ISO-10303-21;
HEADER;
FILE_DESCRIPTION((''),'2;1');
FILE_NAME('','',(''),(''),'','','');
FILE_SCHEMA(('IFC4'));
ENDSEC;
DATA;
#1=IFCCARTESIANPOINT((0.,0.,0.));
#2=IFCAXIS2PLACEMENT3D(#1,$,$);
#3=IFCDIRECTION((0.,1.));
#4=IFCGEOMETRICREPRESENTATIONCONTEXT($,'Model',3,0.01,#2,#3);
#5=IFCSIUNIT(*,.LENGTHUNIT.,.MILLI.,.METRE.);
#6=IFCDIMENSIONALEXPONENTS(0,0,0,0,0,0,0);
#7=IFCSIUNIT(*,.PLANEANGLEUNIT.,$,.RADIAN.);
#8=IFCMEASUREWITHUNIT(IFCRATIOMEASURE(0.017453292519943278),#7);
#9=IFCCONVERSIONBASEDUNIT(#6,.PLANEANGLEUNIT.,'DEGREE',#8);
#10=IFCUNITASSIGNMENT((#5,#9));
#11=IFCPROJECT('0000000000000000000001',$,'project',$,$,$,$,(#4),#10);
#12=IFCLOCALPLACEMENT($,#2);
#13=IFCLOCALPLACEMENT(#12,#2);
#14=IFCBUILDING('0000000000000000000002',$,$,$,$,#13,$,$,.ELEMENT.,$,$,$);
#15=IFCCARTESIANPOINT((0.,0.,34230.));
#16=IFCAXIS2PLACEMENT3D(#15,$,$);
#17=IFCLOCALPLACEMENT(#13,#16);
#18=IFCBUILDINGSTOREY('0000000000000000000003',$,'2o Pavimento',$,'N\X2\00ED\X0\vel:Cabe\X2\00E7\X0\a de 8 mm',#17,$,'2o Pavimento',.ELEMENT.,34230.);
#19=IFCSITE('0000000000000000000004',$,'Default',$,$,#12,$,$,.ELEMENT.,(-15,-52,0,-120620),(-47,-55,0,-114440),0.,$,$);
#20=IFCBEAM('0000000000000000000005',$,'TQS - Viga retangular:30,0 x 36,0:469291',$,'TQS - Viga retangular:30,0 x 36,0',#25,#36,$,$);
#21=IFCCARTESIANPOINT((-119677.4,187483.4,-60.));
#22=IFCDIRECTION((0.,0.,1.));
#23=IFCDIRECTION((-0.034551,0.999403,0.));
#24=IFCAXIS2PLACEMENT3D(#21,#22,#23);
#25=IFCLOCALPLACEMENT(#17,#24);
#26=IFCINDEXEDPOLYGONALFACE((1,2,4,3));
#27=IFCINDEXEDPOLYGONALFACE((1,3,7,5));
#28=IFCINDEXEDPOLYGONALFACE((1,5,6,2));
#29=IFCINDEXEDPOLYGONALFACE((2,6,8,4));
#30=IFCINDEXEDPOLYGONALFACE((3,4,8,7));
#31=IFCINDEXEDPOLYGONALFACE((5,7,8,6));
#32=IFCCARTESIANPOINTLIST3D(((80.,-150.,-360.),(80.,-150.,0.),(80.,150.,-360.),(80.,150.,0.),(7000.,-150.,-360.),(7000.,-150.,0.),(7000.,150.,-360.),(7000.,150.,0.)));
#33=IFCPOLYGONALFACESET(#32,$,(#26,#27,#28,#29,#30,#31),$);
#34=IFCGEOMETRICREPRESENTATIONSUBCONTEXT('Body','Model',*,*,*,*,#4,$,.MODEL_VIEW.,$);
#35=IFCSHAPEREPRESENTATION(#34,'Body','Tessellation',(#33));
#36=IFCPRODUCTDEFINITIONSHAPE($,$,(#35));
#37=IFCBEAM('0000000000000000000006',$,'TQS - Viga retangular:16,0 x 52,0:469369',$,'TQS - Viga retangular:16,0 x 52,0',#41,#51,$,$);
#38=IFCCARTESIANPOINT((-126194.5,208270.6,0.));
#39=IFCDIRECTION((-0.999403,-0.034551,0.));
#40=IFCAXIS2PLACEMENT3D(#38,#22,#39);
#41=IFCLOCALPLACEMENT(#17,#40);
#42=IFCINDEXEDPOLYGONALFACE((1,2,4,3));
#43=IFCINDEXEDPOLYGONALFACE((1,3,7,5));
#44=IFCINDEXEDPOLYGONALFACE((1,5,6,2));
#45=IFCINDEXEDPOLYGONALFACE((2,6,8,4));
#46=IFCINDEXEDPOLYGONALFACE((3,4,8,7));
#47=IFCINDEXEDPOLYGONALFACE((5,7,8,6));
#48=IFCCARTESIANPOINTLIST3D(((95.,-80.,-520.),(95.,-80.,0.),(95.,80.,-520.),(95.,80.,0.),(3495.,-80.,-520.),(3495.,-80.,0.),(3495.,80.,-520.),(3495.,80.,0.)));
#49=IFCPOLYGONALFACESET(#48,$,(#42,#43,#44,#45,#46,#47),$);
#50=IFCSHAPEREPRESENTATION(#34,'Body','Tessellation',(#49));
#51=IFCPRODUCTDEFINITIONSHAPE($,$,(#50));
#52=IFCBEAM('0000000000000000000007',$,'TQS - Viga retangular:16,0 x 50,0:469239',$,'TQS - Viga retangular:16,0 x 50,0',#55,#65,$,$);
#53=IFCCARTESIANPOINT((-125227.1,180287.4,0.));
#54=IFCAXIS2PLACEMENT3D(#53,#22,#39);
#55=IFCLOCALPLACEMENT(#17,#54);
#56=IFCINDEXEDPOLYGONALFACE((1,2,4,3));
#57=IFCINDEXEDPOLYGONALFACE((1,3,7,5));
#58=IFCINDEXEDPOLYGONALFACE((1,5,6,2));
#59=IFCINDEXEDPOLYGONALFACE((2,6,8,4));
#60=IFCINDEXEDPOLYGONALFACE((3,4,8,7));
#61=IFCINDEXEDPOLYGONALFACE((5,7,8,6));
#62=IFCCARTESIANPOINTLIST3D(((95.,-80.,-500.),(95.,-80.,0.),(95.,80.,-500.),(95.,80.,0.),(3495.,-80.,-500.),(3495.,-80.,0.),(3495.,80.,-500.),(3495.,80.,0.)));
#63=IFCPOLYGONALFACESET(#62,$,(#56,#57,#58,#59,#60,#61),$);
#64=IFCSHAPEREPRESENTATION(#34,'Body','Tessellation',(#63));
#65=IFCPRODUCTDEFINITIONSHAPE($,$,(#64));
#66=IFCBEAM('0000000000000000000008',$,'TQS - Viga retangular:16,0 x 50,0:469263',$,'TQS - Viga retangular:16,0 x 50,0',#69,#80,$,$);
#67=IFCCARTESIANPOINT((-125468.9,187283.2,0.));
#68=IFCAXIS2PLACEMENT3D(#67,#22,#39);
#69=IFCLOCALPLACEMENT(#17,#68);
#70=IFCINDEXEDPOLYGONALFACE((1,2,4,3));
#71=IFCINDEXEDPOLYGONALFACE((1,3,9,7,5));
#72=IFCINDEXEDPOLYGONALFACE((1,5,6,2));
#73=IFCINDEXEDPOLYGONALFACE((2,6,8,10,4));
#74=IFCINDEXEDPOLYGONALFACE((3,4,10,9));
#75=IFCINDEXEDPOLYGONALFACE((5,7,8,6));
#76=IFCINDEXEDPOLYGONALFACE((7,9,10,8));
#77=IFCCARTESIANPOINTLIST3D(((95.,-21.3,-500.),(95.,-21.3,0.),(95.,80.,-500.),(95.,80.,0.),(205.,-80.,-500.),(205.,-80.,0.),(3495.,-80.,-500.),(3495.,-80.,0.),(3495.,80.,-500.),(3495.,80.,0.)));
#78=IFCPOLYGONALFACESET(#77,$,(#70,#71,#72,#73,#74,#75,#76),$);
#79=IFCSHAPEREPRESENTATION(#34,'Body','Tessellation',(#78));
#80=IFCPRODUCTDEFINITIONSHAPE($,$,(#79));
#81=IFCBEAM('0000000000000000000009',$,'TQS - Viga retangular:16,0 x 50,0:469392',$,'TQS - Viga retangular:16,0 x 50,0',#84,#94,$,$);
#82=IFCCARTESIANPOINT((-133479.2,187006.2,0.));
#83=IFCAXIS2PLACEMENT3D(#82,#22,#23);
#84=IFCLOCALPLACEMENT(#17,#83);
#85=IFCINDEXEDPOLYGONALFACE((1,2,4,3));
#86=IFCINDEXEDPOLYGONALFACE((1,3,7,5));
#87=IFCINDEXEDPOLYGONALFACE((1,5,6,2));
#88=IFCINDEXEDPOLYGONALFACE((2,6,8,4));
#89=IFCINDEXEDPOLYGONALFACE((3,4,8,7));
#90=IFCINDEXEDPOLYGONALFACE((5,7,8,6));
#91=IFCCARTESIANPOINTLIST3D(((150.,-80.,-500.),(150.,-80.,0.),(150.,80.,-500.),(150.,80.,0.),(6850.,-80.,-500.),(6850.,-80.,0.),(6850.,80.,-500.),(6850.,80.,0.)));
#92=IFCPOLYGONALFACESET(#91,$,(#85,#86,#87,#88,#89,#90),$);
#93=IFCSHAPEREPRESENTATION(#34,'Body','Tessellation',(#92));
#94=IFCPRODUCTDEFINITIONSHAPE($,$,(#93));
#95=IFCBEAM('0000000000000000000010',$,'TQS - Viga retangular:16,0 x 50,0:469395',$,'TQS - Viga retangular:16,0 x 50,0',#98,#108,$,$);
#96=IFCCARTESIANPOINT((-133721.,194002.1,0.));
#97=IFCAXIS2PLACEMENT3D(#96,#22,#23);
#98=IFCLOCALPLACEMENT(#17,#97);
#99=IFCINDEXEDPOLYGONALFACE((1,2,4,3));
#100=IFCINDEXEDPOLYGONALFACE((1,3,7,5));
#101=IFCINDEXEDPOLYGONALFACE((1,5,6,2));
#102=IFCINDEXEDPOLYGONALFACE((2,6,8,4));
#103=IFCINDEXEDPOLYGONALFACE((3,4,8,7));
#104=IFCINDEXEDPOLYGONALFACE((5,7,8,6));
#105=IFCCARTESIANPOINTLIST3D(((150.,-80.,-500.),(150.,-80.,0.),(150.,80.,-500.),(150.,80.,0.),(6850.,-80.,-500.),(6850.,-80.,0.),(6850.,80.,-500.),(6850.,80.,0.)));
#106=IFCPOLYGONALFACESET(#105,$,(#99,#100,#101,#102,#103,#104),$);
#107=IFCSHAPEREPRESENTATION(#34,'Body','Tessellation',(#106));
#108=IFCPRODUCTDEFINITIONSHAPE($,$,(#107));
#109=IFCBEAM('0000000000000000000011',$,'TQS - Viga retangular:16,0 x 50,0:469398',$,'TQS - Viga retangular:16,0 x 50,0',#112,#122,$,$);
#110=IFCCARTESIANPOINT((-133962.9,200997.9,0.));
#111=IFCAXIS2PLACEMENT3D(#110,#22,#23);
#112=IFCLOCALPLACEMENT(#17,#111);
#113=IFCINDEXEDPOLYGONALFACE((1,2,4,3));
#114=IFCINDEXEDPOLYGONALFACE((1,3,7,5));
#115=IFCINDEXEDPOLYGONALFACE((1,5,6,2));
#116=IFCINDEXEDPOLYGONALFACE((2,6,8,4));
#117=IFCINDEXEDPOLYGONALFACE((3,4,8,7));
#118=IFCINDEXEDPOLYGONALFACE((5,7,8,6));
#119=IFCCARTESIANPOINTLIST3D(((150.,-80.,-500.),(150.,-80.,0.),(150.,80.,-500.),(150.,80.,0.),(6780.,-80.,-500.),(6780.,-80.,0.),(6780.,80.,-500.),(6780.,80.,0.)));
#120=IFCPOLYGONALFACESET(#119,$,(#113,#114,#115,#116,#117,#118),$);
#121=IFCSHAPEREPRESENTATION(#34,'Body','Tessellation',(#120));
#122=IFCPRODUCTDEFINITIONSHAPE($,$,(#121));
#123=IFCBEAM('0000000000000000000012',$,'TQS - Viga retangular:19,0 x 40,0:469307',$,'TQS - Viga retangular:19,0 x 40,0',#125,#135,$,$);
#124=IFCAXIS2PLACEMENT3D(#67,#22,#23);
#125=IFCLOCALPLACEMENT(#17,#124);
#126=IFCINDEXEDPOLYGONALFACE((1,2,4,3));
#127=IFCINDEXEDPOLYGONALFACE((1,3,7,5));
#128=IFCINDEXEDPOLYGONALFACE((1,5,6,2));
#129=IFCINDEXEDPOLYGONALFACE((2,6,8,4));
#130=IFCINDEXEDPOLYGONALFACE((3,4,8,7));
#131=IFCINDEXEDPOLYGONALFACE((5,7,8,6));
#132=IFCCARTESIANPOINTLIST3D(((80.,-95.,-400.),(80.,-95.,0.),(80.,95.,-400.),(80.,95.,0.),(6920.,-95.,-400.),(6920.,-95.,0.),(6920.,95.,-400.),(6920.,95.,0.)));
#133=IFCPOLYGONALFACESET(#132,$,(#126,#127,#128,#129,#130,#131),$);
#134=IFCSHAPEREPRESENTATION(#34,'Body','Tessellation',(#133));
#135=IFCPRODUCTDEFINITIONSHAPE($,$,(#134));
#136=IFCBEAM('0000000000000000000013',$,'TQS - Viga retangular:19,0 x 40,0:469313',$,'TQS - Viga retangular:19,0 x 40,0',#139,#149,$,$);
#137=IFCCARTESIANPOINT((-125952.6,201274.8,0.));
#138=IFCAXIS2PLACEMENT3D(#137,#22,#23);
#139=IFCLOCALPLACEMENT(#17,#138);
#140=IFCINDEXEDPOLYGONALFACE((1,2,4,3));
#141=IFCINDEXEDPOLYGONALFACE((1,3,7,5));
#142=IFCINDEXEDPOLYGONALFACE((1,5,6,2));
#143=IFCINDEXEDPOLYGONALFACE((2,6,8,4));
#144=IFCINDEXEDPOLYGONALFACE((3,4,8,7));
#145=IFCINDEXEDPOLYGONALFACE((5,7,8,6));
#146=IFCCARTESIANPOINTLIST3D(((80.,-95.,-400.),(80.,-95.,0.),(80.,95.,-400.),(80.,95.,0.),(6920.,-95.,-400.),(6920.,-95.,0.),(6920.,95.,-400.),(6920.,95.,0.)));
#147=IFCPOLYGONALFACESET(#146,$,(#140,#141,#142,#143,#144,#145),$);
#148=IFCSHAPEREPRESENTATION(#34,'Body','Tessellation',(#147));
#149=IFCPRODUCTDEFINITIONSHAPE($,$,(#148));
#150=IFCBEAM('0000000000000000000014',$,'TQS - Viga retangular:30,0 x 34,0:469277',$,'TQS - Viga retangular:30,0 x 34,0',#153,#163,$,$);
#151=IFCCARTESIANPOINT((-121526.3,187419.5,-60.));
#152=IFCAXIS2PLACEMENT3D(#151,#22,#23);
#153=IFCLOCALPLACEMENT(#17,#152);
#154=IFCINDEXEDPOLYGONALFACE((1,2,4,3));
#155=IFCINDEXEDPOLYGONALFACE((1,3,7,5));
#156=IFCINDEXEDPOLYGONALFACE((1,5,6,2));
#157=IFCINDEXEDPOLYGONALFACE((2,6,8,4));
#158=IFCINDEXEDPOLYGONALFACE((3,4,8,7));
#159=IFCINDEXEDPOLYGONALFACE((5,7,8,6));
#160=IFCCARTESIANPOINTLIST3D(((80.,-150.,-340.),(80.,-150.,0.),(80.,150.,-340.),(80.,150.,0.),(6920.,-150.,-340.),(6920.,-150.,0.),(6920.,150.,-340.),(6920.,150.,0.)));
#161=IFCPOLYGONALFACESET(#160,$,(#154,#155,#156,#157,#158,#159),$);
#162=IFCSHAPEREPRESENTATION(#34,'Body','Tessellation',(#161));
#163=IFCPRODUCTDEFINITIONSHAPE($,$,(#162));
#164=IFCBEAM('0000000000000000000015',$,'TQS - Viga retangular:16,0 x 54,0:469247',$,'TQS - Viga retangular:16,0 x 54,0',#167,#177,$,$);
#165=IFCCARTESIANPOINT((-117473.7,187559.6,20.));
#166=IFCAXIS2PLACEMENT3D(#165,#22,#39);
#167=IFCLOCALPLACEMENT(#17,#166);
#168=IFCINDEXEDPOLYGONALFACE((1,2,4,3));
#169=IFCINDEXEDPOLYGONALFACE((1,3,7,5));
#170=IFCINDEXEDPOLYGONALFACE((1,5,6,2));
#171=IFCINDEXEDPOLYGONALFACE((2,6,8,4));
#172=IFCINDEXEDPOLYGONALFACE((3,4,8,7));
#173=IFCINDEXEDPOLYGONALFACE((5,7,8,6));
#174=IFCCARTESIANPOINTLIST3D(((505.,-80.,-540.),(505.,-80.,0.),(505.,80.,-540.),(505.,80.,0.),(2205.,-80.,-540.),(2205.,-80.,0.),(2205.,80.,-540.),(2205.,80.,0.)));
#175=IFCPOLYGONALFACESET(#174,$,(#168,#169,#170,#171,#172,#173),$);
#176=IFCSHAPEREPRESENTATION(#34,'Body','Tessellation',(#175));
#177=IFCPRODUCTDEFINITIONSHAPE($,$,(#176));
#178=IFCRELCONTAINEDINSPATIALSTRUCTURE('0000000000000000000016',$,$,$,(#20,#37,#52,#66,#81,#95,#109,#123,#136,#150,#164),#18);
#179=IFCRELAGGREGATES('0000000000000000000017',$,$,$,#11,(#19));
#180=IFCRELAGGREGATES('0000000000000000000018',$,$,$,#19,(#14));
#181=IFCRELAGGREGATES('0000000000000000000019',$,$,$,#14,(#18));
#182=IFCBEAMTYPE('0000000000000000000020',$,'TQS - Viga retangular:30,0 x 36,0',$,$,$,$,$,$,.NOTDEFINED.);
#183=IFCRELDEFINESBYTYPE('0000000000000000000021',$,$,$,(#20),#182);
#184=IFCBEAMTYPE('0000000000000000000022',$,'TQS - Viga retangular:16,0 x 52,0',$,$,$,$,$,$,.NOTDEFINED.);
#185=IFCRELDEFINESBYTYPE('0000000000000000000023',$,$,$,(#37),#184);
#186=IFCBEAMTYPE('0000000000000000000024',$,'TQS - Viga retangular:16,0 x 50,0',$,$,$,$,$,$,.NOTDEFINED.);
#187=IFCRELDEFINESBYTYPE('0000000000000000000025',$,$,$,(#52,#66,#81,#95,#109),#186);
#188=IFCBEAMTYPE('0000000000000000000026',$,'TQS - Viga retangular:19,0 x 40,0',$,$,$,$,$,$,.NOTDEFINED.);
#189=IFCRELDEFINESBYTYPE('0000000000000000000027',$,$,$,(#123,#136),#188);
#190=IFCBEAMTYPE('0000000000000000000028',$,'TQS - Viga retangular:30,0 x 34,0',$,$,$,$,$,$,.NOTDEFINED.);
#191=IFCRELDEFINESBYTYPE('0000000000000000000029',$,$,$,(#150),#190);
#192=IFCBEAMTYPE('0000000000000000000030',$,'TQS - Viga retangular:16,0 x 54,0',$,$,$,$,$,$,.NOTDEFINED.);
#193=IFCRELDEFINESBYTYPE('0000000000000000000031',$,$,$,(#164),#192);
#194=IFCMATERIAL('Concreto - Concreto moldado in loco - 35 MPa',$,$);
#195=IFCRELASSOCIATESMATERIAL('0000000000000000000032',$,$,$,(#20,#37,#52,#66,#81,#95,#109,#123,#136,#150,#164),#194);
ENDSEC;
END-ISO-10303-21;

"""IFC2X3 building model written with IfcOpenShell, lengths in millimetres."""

from ifc_helpers import new_model, entity, si_unit, converted_unit, direction, frame, frame_2d, origin, origin_2d_with_axis, place, context, subcontext, project, spatial, rectangle, extrude, clip, halfspace, material, type_object, element, save


model = new_model("IFC2X3")

# Units and contexts
model_context = context("Model", 3, precision=0.01, world=origin(), true_north=direction((0.0, 1.0)))
body_context = subcontext(model_context, "Body", "Model", "MODEL_VIEW")
ifc_project = project(units=[si_unit("LENGTHUNIT", "METRE", prefix="MILLI"), converted_unit("PLANEANGLEUNIT", "DEGREE", entity("IfcRatioMeasure", 0.017453292519943278), si_unit("PLANEANGLEUNIT", "RADIAN"), dimensions=[0, 0, 0, 0, 0, 0, 0])], contexts=[model_context])

# Site, building, storey
site_placement = place(None, origin())
site = spatial("IfcSite", under=ifc_project, at=site_placement, Name="Default", CompositionType="ELEMENT", RefLatitude=(-15, -52, 0, -120620), RefLongitude=(-47, -55, 0, -114440), RefElevation=0.0)
building_placement = place(site_placement, origin())
building = spatial("IfcBuilding", under=site, at=building_placement, CompositionType="ELEMENT")
storey_placement = place(building_placement, frame((0.0, 0.0, 34230.0)))
storey = spatial("IfcBuildingStorey", under=building, at=storey_placement, Name="2o Pavimento", ObjectType="Nível:Cabeça de 8 mm", LongName="2o Pavimento", CompositionType="ELEMENT", Elevation=34230.0)

# Beams
ifc_material = material(Name="Concreto - Concreto moldado in loco - 35 MPa")
beam_type_1 = type_object("IfcBeamType", Name="TQS - Viga retangular:30,0 x 36,0", PredefinedType="NOTDEFINED")
beam_1_placement = place(storey_placement, frame((-119677.4, 187483.4, -60.0), z_axis=(0.0, 0.0, 1.0), x_axis=(-0.034551, 0.999403, 0.0)))
element("IfcBeam", 1, at=beam_1_placement, inside=storey, type_object=beam_type_1, material=ifc_material, Name="TQS - Viga retangular:30,0 x 36,0:469291", ObjectType="TQS - Viga retangular:30,0 x 36,0", context=body_context, shape_type="SweptSolid", body=[
    extrude(rectangle(XDim=360.0, YDim=300.0, at=frame_2d((0.0, 0.0), x_axis=(1.0, 0.0))), frame((80.0, 0.0, -180.0), z_axis=(1.0, 0.0, 0.0), x_axis=(0.0, 0.0, -1.0)), (0.0, 0.0, 1.0), 6920.0),
])
beam_type_2 = type_object("IfcBeamType", Name="TQS - Viga retangular:16,0 x 52,0", PredefinedType="NOTDEFINED")
beam_2_placement = place(storey_placement, frame((-126194.5, 208270.6, 0.0), z_axis=(0.0, 0.0, 1.0), x_axis=(-0.999403, -0.034551, 0.0)))
element("IfcBeam", 2, at=beam_2_placement, inside=storey, type_object=beam_type_2, material=ifc_material, Name="TQS - Viga retangular:16,0 x 52,0:469369", ObjectType="TQS - Viga retangular:16,0 x 52,0", context=body_context, shape_type="SweptSolid", body=[
    extrude(rectangle(XDim=520.0, YDim=160.0, at=frame_2d((0.0, 0.0), x_axis=(1.0, 0.0))), frame((95.0, 0.0, -260.0), z_axis=(1.0, 0.0, 0.0), x_axis=(0.0, 0.0, -1.0)), (0.0, 0.0, 1.0), 3400.0),
])
beam_type_3 = type_object("IfcBeamType", Name="TQS - Viga retangular:16,0 x 50,0", PredefinedType="NOTDEFINED")
beam_3_placement = place(storey_placement, frame((-125227.1, 180287.4, 0.0), z_axis=(0.0, 0.0, 1.0), x_axis=(-0.999403, -0.034551, 0.0)))
element("IfcBeam", 3, at=beam_3_placement, inside=storey, type_object=beam_type_3, material=ifc_material, Name="TQS - Viga retangular:16,0 x 50,0:469239", ObjectType="TQS - Viga retangular:16,0 x 50,0", context=body_context, shape_type="SweptSolid", body=[
    extrude(rectangle(XDim=500.0, YDim=160.0, at=origin_2d_with_axis()), frame((95.0, 0.0, -250.0), z_axis=(1.0, 0.0, 0.0), x_axis=(0.0, 0.0, -1.0)), (0.0, 0.0, 1.0), 3400.0),
])
beam_4_placement = place(storey_placement, frame((-125468.9, 187283.2, 0.0), z_axis=(0.0, 0.0, 1.0), x_axis=(-0.999403, -0.034551, 0.0)))
element("IfcBeam", 4, at=beam_4_placement, inside=storey, type_object=beam_type_3, material=ifc_material, Name="TQS - Viga retangular:16,0 x 50,0:469263", ObjectType="TQS - Viga retangular:16,0 x 50,0", context=body_context, shape_type="SweptSolid", body=[
    clip(extrude(rectangle(XDim=500.0, YDim=160.0, at=frame_2d((0.0, 0.0), x_axis=(1.0, 0.0))), frame((95.0, 0.0, -250.0), z_axis=(1.0, 0.0, 0.0), x_axis=(0.0, 0.0, -1.0)), (0.0, 0.0, 1.0), 3400.0), halfspace(frame((-95.0, 80.0, 0.0), z_axis=(-0.470588, -0.882353, 0.0), x_axis=(-0.882353, 0.470588, 0.0)), False)),
])
beam_5_placement = place(storey_placement, frame((-133479.2, 187006.2, 0.0), z_axis=(0.0, 0.0, 1.0), x_axis=(-0.034551, 0.999403, 0.0)))
element("IfcBeam", 5, at=beam_5_placement, inside=storey, type_object=beam_type_3, material=ifc_material, Name="TQS - Viga retangular:16,0 x 50,0:469392", ObjectType="TQS - Viga retangular:16,0 x 50,0", context=body_context, shape_type="SweptSolid", body=[
    extrude(rectangle(XDim=500.0, YDim=160.0, at=frame_2d((0.0, 0.0), x_axis=(1.0, 0.0))), frame((150.0, 0.0, -250.0), z_axis=(1.0, 0.0, 0.0), x_axis=(0.0, 0.0, -1.0)), (0.0, 0.0, 1.0), 6700.0),
])
beam_6_placement = place(storey_placement, frame((-133721.0, 194002.1, 0.0), z_axis=(0.0, 0.0, 1.0), x_axis=(-0.034551, 0.999403, 0.0)))
element("IfcBeam", 6, at=beam_6_placement, inside=storey, type_object=beam_type_3, material=ifc_material, Name="TQS - Viga retangular:16,0 x 50,0:469395", ObjectType="TQS - Viga retangular:16,0 x 50,0", context=body_context, shape_type="SweptSolid", body=[
    extrude(rectangle(XDim=500.0, YDim=160.0, at=frame_2d((0.0, 0.0), x_axis=(1.0, 0.0))), frame((150.0, 0.0, -250.0), z_axis=(1.0, 0.0, 0.0), x_axis=(0.0, 0.0, -1.0)), (0.0, 0.0, 1.0), 6700.0),
])
beam_7_placement = place(storey_placement, frame((-133962.9, 200997.9, 0.0), z_axis=(0.0, 0.0, 1.0), x_axis=(-0.034551, 0.999403, 0.0)))
element("IfcBeam", 7, at=beam_7_placement, inside=storey, type_object=beam_type_3, material=ifc_material, Name="TQS - Viga retangular:16,0 x 50,0:469398", ObjectType="TQS - Viga retangular:16,0 x 50,0", context=body_context, shape_type="SweptSolid", body=[
    extrude(rectangle(XDim=500.0, YDim=160.0, at=frame_2d((0.0, 0.0), x_axis=(1.0, 0.0))), frame((150.0, 0.0, -250.0), z_axis=(1.0, 0.0, 0.0), x_axis=(0.0, 0.0, -1.0)), (0.0, 0.0, 1.0), 6630.0),
])
beam_type_4 = type_object("IfcBeamType", Name="TQS - Viga retangular:19,0 x 40,0", PredefinedType="NOTDEFINED")
beam_8_placement = place(storey_placement, frame((-125468.9, 187283.2, 0.0), z_axis=(0.0, 0.0, 1.0), x_axis=(-0.034551, 0.999403, 0.0)))
element("IfcBeam", 8, at=beam_8_placement, inside=storey, type_object=beam_type_4, material=ifc_material, Name="TQS - Viga retangular:19,0 x 40,0:469307", ObjectType="TQS - Viga retangular:19,0 x 40,0", context=body_context, shape_type="SweptSolid", body=[
    extrude(rectangle(XDim=400.0, YDim=190.0, at=frame_2d((0.0, 0.0), x_axis=(1.0, 0.0))), frame((80.0, 0.0, -200.0), z_axis=(1.0, 0.0, 0.0), x_axis=(0.0, 0.0, -1.0)), (0.0, 0.0, 1.0), 6840.0),
])
beam_9_placement = place(storey_placement, frame((-125952.6, 201274.8, 0.0), z_axis=(0.0, 0.0, 1.0), x_axis=(-0.034551, 0.999403, 0.0)))
element("IfcBeam", 9, at=beam_9_placement, inside=storey, type_object=beam_type_4, material=ifc_material, Name="TQS - Viga retangular:19,0 x 40,0:469313", ObjectType="TQS - Viga retangular:19,0 x 40,0", context=body_context, shape_type="SweptSolid", body=[
    extrude(rectangle(XDim=400.0, YDim=190.0, at=frame_2d((0.0, 0.0), x_axis=(1.0, 0.0))), frame((80.0, 0.0, -200.0), z_axis=(1.0, 0.0, 0.0), x_axis=(0.0, 0.0, -1.0)), (0.0, 0.0, 1.0), 6840.0),
])
beam_type_5 = type_object("IfcBeamType", Name="TQS - Viga retangular:30,0 x 34,0", PredefinedType="NOTDEFINED")
beam_10_placement = place(storey_placement, frame((-121526.3, 187419.5, -60.0), z_axis=(0.0, 0.0, 1.0), x_axis=(-0.034551, 0.999403, 0.0)))
element("IfcBeam", 10, at=beam_10_placement, inside=storey, type_object=beam_type_5, material=ifc_material, Name="TQS - Viga retangular:30,0 x 34,0:469277", ObjectType="TQS - Viga retangular:30,0 x 34,0", context=body_context, shape_type="SweptSolid", body=[
    extrude(rectangle(XDim=340.0, YDim=300.0, at=frame_2d((0.0, 0.0), x_axis=(1.0, 0.0))), frame((80.0, 0.0, -170.0), z_axis=(1.0, 0.0, 0.0), x_axis=(0.0, 0.0, -1.0)), (0.0, 0.0, 1.0), 6840.0),
])
beam_type_6 = type_object("IfcBeamType", Name="TQS - Viga retangular:16,0 x 54,0", PredefinedType="NOTDEFINED")
beam_11_placement = place(storey_placement, frame((-117473.7, 187559.6, 20.0), z_axis=(0.0, 0.0, 1.0), x_axis=(-0.999403, -0.034551, 0.0)))
element("IfcBeam", 11, at=beam_11_placement, inside=storey, type_object=beam_type_6, material=ifc_material, Name="TQS - Viga retangular:16,0 x 54,0:469247", ObjectType="TQS - Viga retangular:16,0 x 54,0", context=body_context, shape_type="SweptSolid", body=[
    extrude(rectangle(XDim=540.0, YDim=160.0, at=frame_2d((0.0, 0.0), x_axis=(1.0, 0.0))), frame((505.0, 0.0, -270.0), z_axis=(1.0, 0.0, 0.0), x_axis=(0.0, 0.0, -1.0)), (0.0, 0.0, 1.0), 1700.0),
])

save(model, "model.ifc")
